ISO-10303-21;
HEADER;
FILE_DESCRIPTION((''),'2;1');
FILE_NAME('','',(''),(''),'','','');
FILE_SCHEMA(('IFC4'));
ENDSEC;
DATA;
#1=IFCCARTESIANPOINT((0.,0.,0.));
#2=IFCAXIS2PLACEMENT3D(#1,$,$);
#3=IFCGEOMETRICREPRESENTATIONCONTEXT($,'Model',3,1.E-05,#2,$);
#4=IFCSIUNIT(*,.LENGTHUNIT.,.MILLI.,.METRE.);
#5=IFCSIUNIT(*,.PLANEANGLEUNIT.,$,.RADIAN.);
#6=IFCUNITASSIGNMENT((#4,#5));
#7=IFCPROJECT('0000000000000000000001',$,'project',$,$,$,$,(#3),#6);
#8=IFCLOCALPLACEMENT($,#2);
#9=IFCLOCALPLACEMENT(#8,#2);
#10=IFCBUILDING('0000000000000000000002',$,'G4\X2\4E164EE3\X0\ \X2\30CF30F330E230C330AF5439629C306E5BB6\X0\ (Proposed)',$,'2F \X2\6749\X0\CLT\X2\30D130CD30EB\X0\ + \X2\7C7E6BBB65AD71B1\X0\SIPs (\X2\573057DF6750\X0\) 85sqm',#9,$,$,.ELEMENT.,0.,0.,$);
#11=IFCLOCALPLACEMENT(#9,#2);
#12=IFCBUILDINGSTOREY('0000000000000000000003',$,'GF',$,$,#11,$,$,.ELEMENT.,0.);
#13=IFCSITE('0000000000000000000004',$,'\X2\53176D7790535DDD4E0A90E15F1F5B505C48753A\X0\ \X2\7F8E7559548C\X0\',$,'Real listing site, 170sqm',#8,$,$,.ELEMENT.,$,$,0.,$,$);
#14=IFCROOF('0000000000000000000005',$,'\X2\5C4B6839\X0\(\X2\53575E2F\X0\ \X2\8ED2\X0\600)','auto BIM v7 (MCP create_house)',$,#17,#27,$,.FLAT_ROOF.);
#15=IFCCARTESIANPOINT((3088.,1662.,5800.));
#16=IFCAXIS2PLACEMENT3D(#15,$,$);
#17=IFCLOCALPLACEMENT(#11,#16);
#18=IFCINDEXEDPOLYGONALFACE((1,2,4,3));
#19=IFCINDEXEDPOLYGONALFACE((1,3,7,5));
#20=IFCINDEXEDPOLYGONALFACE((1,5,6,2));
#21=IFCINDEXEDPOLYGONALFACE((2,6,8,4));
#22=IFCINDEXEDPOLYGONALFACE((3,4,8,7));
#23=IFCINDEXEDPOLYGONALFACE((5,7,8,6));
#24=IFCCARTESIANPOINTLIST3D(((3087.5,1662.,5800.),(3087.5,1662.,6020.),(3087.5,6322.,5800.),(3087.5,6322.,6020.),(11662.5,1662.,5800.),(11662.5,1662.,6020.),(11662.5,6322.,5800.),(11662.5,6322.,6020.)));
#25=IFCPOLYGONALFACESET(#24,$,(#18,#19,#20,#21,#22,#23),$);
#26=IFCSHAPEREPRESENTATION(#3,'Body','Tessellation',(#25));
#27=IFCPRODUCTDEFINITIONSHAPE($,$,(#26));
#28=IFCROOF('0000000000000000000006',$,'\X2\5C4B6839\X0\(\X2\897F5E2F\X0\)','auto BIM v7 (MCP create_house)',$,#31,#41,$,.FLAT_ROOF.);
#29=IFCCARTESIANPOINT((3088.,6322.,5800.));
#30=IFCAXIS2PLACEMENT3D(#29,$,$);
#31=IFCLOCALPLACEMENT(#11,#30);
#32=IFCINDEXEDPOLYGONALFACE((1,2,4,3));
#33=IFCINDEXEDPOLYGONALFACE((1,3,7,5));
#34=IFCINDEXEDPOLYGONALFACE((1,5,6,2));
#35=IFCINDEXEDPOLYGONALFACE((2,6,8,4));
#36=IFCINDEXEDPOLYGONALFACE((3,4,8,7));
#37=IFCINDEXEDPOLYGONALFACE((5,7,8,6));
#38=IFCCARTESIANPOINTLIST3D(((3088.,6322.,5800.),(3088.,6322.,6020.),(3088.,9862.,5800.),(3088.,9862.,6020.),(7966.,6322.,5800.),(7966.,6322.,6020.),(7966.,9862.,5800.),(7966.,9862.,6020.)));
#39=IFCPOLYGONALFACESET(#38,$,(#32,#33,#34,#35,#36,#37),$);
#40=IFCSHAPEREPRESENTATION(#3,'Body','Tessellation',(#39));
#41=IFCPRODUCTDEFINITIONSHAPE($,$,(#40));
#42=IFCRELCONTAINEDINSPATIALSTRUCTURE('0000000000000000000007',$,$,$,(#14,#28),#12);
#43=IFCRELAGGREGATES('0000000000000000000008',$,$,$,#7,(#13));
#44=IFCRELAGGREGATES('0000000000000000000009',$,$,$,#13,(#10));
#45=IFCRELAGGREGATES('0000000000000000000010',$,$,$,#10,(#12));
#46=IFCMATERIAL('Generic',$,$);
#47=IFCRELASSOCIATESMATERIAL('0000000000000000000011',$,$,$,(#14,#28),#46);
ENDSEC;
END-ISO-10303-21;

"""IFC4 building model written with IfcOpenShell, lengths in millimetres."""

from ifc_helpers import new_model, si_unit, frame, frame_2d, origin, place, context, project, spatial, rectangle, extrude, material, element, save


model = new_model("IFC4")

# Units and contexts
model_context = context("Model", 3, precision=1e-05, world=origin())
ifc_project = project(units=[si_unit("LENGTHUNIT", "METRE", prefix="MILLI"), si_unit("PLANEANGLEUNIT", "RADIAN")], contexts=[model_context])

# Site, building, storey
site_placement = place(None, origin())
site = spatial("IfcSite", under=ifc_project, at=site_placement, Name="北海道川上郡弟子屈町 美留和", ObjectType="Real listing site, 170sqm", CompositionType="ELEMENT", RefElevation=0.0)
building_placement = place(site_placement, origin())
building = spatial("IfcBuilding", under=site, at=building_placement, Name="G4世代 ハンモック吹抜の家 (Proposed)", ObjectType="2F 杉CLTパネル + 籾殻断熱SIPs (地域材) 85sqm", CompositionType="ELEMENT", ElevationOfRefHeight=0.0, ElevationOfTerrain=0.0)
storey_placement = place(building_placement, origin())
storey = spatial("IfcBuildingStorey", under=building, at=storey_placement, Name="GF", CompositionType="ELEMENT", Elevation=0.0)

# Shared definitions
ifc_material = material(Name="Generic")

# Roofs
roof_1_placement = place(storey_placement, frame((3088.0, 1662.0, 5800.0)))
element("IfcRoof", 1, at=roof_1_placement, inside=storey, material=ifc_material, Name="屋根(南帯 軒600)", Description="auto BIM v7 (MCP create_house)", PredefinedType="FLAT_ROOF", context=model_context, shape_type="SweptSolid", body=[
    extrude(rectangle(XDim=8575.0, YDim=4660.0, at=frame_2d((4287.0, 2330.0))), frame((3088.0, 1662.0, 5800.0)), (0.0, 0.0, 1.0), 220.0),
])
roof_2_placement = place(storey_placement, frame((3088.0, 6322.0, 5800.0)))
element("IfcRoof", 2, at=roof_2_placement, inside=storey, material=ifc_material, Name="屋根(西帯)", Description="auto BIM v7 (MCP create_house)", PredefinedType="FLAT_ROOF", context=model_context, shape_type="SweptSolid", body=[
    extrude(rectangle(XDim=4878.0, YDim=3540.0, at=frame_2d((2439.0, 1770.0))), frame((3088.0, 6322.0, 5800.0)), (0.0, 0.0, 1.0), 220.0),
])

save(model, "model.ifc")
